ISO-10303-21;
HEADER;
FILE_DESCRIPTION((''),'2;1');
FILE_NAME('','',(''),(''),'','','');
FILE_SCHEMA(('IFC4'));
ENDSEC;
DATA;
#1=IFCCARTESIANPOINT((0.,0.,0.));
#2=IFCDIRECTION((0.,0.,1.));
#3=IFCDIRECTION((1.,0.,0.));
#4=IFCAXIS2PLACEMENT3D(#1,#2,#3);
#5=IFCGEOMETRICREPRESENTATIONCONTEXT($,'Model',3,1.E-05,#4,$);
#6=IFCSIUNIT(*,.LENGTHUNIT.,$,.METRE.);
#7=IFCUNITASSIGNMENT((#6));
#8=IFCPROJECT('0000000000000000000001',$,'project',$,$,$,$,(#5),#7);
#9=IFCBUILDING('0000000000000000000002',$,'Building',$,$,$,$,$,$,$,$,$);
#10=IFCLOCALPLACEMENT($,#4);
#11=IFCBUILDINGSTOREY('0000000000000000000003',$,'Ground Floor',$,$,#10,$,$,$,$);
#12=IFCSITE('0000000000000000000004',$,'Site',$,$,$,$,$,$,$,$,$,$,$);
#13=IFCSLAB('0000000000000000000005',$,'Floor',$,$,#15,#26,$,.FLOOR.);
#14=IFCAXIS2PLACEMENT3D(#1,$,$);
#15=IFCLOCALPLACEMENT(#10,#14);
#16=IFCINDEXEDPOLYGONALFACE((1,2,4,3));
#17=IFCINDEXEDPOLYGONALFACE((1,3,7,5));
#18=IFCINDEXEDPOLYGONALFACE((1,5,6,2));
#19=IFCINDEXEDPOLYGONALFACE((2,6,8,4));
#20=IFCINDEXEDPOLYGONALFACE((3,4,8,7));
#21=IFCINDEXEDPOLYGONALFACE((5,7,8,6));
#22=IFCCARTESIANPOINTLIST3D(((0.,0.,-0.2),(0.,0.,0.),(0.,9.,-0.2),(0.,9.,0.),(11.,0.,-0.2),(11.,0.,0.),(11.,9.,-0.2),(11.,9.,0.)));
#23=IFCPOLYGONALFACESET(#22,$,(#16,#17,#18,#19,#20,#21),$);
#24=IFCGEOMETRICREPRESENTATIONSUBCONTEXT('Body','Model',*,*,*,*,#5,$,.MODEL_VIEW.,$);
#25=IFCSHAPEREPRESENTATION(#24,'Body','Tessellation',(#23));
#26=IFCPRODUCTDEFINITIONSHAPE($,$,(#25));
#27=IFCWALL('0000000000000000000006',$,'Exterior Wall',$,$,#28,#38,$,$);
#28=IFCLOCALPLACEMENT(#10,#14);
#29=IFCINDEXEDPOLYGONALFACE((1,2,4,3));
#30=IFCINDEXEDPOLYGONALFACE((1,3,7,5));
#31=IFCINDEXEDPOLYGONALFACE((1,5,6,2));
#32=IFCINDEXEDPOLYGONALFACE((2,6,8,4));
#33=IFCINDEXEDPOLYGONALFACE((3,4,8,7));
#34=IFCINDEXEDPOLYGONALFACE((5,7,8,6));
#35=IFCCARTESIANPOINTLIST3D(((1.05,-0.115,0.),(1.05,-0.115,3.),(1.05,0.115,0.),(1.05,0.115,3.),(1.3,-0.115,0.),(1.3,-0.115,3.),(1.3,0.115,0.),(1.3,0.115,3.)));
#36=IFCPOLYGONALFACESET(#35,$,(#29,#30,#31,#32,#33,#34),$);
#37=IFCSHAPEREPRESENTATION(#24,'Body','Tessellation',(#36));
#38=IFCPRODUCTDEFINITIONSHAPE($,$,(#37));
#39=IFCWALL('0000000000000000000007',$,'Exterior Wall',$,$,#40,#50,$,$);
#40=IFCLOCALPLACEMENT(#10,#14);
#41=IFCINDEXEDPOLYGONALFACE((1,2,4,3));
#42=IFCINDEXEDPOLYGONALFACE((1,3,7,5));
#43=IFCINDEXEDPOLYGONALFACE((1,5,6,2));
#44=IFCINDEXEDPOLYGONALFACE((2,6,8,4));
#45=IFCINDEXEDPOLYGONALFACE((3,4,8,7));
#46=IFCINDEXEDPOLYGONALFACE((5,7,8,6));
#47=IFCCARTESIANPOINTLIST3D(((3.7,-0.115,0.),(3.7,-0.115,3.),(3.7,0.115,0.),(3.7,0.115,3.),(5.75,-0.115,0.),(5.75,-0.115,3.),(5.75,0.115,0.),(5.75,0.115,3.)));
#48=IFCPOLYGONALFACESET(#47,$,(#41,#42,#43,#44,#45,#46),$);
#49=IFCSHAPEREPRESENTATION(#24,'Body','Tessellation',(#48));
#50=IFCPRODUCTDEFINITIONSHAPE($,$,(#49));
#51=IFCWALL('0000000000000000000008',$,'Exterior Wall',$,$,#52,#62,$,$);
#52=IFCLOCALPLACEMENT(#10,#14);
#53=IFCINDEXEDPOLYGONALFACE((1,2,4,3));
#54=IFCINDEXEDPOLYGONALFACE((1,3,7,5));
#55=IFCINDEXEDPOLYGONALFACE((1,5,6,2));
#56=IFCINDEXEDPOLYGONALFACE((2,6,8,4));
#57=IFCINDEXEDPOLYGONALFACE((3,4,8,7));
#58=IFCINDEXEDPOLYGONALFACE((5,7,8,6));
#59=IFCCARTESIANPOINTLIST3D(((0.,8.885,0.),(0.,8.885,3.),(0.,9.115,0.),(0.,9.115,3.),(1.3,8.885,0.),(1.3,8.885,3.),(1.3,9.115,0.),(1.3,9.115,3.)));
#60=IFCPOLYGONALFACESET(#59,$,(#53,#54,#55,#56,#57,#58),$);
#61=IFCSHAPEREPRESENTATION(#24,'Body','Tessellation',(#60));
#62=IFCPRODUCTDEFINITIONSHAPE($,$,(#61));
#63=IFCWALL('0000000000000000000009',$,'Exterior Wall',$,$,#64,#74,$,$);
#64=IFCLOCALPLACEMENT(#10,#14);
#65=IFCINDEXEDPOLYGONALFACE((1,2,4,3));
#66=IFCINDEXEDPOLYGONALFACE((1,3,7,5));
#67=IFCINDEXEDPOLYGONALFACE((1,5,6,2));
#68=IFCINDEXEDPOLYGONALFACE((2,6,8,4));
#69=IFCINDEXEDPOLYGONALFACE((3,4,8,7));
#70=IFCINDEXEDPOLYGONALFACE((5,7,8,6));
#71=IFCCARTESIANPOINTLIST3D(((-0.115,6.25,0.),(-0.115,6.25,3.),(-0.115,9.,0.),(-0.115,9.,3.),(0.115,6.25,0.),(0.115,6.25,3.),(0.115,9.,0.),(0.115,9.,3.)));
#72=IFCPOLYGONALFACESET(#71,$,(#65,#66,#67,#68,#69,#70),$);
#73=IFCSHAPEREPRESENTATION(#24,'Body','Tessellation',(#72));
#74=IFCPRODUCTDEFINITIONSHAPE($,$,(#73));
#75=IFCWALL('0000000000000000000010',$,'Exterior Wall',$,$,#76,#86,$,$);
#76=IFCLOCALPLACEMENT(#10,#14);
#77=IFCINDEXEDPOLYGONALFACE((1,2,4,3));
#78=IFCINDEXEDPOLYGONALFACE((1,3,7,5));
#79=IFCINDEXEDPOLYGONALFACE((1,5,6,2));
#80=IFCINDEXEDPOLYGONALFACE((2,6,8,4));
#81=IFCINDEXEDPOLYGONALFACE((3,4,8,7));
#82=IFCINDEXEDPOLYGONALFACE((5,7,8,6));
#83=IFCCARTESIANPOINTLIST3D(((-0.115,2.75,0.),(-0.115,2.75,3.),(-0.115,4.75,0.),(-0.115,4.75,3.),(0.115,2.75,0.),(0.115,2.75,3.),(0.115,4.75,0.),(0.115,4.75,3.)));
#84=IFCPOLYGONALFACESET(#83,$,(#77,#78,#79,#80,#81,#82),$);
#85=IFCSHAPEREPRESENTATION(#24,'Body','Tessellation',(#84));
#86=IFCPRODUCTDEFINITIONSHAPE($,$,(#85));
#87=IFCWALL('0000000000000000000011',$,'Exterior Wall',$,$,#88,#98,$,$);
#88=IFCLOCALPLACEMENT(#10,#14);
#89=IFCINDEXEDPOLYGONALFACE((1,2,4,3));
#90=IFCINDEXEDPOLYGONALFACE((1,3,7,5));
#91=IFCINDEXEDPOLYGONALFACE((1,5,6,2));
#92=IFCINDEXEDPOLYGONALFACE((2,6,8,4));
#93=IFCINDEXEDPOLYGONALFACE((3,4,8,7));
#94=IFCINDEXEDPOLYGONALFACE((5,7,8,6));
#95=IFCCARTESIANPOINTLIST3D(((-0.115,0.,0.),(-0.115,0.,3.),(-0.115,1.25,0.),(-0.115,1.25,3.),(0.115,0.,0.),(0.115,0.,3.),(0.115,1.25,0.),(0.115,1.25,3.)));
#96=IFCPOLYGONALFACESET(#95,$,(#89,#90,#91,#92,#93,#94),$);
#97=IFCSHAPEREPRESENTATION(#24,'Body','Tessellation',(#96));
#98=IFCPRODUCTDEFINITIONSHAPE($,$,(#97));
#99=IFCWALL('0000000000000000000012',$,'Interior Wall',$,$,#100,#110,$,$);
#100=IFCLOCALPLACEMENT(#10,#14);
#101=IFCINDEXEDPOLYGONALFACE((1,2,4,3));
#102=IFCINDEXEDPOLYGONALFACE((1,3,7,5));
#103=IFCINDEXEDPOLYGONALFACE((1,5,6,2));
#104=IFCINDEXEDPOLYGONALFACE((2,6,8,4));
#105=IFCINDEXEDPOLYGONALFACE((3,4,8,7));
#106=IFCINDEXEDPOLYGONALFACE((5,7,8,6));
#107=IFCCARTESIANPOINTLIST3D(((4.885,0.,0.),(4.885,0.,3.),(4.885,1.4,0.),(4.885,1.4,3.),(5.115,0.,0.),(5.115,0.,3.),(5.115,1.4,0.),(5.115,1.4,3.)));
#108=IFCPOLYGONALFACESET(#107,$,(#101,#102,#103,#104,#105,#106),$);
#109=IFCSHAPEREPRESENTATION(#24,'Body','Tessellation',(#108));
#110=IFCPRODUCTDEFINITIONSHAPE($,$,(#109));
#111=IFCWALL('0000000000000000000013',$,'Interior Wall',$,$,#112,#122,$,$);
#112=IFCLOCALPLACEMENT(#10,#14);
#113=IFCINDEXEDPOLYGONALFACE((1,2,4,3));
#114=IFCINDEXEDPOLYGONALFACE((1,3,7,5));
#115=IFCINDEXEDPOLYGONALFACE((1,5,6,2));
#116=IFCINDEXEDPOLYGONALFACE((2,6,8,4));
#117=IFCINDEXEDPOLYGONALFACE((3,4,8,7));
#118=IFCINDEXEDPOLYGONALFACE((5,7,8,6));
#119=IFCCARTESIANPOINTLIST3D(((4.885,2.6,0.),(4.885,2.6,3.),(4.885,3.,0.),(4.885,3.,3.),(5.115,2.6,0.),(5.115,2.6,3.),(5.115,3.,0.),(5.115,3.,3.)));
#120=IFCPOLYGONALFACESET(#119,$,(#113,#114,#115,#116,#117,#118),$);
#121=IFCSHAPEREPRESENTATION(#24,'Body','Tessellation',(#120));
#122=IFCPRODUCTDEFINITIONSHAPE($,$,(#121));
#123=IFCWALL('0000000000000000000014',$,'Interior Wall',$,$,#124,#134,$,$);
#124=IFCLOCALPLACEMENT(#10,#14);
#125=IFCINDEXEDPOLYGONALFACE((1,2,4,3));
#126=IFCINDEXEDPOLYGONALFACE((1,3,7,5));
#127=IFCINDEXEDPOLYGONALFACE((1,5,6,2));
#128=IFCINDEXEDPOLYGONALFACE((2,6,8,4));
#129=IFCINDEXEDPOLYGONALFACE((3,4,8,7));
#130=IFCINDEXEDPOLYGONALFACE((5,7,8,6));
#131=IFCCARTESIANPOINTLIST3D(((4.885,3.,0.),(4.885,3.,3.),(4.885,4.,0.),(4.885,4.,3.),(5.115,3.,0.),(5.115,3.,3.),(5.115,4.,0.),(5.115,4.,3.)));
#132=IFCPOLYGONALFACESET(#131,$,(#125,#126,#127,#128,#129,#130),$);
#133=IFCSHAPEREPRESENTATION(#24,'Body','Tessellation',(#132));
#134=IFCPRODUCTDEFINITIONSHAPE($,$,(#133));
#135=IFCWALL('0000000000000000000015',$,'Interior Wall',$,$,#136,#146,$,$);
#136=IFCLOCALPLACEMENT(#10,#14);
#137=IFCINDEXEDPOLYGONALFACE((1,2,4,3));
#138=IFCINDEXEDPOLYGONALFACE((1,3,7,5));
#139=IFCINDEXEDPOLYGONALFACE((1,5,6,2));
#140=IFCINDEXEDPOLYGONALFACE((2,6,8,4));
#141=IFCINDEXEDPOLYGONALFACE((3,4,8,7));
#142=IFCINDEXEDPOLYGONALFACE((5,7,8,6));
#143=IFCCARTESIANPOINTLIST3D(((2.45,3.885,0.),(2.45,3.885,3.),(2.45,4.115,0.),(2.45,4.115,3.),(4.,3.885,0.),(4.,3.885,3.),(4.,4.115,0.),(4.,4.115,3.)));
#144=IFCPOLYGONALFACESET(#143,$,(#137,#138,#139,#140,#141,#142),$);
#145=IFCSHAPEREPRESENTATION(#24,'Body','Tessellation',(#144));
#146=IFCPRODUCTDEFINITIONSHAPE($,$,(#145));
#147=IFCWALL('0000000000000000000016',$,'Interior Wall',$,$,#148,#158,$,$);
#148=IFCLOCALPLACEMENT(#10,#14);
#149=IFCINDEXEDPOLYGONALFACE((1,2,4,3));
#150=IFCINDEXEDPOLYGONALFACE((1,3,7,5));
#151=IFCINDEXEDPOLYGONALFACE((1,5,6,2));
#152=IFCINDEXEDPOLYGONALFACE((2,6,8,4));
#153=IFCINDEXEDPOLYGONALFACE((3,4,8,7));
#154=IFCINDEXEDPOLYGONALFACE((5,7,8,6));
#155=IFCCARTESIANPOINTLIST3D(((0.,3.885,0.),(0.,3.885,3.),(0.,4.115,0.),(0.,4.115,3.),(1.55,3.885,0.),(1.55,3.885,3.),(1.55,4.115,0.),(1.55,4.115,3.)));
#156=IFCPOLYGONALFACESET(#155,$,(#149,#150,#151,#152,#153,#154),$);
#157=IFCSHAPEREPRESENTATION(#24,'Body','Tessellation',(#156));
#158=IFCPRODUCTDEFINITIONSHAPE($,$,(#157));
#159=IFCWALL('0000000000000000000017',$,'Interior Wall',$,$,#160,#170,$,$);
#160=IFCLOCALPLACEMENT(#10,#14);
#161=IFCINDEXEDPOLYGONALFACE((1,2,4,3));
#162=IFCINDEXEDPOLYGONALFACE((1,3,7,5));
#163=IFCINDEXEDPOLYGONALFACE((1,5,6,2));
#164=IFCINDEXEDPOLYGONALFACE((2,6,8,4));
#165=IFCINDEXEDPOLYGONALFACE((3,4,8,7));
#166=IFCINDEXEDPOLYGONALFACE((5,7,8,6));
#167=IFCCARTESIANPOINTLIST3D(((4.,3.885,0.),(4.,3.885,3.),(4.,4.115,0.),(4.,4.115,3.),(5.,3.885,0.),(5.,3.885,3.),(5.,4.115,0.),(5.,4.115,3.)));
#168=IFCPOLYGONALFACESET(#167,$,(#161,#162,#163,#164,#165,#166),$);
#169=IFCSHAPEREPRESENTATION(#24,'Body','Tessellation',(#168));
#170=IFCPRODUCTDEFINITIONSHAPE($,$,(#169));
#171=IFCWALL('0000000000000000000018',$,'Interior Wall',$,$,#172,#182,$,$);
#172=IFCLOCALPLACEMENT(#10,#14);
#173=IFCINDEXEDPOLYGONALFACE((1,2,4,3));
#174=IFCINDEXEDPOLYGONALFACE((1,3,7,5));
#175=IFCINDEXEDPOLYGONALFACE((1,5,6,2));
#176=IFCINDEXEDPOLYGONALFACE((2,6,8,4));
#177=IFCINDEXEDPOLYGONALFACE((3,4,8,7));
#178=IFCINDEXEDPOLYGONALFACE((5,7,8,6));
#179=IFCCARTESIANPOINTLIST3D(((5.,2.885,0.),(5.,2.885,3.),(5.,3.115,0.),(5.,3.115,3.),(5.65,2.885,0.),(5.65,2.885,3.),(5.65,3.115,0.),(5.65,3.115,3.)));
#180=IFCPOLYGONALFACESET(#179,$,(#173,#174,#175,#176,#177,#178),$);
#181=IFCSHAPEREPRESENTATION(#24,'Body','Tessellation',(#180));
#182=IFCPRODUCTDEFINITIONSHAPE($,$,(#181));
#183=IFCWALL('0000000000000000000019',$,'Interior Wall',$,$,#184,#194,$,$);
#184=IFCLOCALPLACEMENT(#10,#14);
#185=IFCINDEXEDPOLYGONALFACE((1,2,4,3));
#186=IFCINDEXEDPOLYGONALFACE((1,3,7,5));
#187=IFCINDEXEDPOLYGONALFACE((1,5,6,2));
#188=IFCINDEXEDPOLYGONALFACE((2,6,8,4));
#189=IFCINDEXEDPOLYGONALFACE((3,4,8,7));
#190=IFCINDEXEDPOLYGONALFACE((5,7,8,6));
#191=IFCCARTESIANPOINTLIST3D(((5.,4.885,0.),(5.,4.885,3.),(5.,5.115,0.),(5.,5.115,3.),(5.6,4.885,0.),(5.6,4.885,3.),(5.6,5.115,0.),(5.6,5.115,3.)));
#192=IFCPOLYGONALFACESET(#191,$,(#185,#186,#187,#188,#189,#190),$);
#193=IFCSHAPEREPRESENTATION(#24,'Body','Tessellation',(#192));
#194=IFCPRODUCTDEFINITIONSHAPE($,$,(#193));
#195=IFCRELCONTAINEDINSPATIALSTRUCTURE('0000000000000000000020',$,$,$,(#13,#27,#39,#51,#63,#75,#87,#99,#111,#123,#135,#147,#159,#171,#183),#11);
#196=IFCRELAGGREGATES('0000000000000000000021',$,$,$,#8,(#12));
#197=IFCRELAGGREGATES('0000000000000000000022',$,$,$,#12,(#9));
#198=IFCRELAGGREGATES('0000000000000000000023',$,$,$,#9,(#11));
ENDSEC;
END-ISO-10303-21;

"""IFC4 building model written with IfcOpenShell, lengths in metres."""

from ifc_helpers import new_model, si_unit, frame, origin_with_axes, place, context, subcontext, project, spatial, indexed_curve, outline, extrude, element, save


model = new_model("IFC4")

# Units and contexts
model_context = context("Model", 3, precision=1e-05, world=origin_with_axes())
body_context = subcontext(model_context, "Body", "Model", "MODEL_VIEW")
ifc_project = project(units=[si_unit("LENGTHUNIT", "METRE")], contexts=[model_context])

# Site, building, storey
site = spatial("IfcSite", under=ifc_project, Name="Site")
building = spatial("IfcBuilding", under=site, Name="Building")
storey_placement = place(None, origin_with_axes())
storey = spatial("IfcBuildingStorey", under=building, at=storey_placement, Name="Ground Floor")

# Slab
slab_placement = place(storey_placement, frame((0.0, 0.0, -0.2), z_axis=(0.0, 0.0, 1.0), x_axis=(1.0, 0.0, 0.0)))
element("IfcSlab", 1, at=slab_placement, inside=storey, Name="Floor", PredefinedType="FLOOR", context=body_context, shape_type="SweptSolid", body=[
    extrude(outline(indexed_curve([(0.0, 0.0), (11.0, 0.0), (11.0, 9.0), (0.0, 9.0)])), None, (0.0, 0.0, 1.0), 0.2),
])

# Walls
wall_1_placement = place(storey_placement, frame((1.05, 0.0, 0.0), z_axis=(0.0, 0.0, 1.0), x_axis=(1.0, 0.0, 0.0)))
element("IfcWall", 2, at=wall_1_placement, inside=storey, Name="Exterior Wall", context=body_context, shape_type="SweptSolid", body=[
    extrude(outline(indexed_curve([(0.0, 0.0), (0.0, 0.23), (0.25, 0.23), (0.25, 0.0), (0.0, 0.0)], self_intersect=False)), frame((0.0, -0.115, 0.0), z_axis=(0.0, 0.0, 1.0), x_axis=(1.0, 0.0, 0.0)), (0.0, 0.0, 1.0), 3.0),
])
wall_2_placement = place(storey_placement, frame((3.7, 0.0, 0.0), z_axis=(0.0, 0.0, 1.0), x_axis=(1.0, 0.0, 0.0)))
element("IfcWall", 3, at=wall_2_placement, inside=storey, Name="Exterior Wall", context=body_context, shape_type="SweptSolid", body=[
    extrude(outline(indexed_curve([(0.0, 0.0), (0.0, 0.23), (2.05, 0.23), (2.05, 0.0), (0.0, 0.0)], self_intersect=False)), frame((0.0, -0.115, 0.0), z_axis=(0.0, 0.0, 1.0), x_axis=(1.0, 0.0, 0.0)), (0.0, 0.0, 1.0), 3.0),
])
wall_3_placement = place(storey_placement, frame((1.3, 9.0, 0.0), z_axis=(0.0, 0.0, 1.0), x_axis=(-1.0, 0.0, 0.0)))
element("IfcWall", 4, at=wall_3_placement, inside=storey, Name="Exterior Wall", context=body_context, shape_type="SweptSolid", body=[
    extrude(outline(indexed_curve([(0.0, 0.0), (0.0, 0.23), (1.3, 0.23), (1.3, 0.0), (0.0, 0.0)], self_intersect=False)), frame((0.0, -0.115, 0.0), z_axis=(0.0, 0.0, 1.0), x_axis=(1.0, 0.0, 0.0)), (0.0, 0.0, 1.0), 3.0),
])
wall_4_placement = place(storey_placement, frame((0.0, 9.0, 0.0), z_axis=(0.0, 0.0, 1.0), x_axis=(0.0, -1.0, 0.0)))
element("IfcWall", 5, at=wall_4_placement, inside=storey, Name="Exterior Wall", context=body_context, shape_type="SweptSolid", body=[
    extrude(outline(indexed_curve([(0.0, 0.0), (0.0, 0.23), (2.75, 0.23), (2.75, 0.0), (0.0, 0.0)], self_intersect=False)), frame((0.0, -0.115, 0.0), z_axis=(0.0, 0.0, 1.0), x_axis=(1.0, 0.0, 0.0)), (0.0, 0.0, 1.0), 3.0),
])
wall_5_placement = place(storey_placement, frame((0.0, 4.75, 0.0), z_axis=(0.0, 0.0, 1.0), x_axis=(0.0, -1.0, 0.0)))
element("IfcWall", 6, at=wall_5_placement, inside=storey, Name="Exterior Wall", context=body_context, shape_type="SweptSolid", body=[
    extrude(outline(indexed_curve([(0.0, 0.0), (0.0, 0.23), (2.0, 0.23), (2.0, 0.0), (0.0, 0.0)], self_intersect=False)), frame((0.0, -0.115, 0.0), z_axis=(0.0, 0.0, 1.0), x_axis=(1.0, 0.0, 0.0)), (0.0, 0.0, 1.0), 3.0),
])
wall_6_placement = place(storey_placement, frame((0.0, 1.25, 0.0), z_axis=(0.0, 0.0, 1.0), x_axis=(0.0, -1.0, 0.0)))
element("IfcWall", 7, at=wall_6_placement, inside=storey, Name="Exterior Wall", context=body_context, shape_type="SweptSolid", body=[
    extrude(outline(indexed_curve([(0.0, 0.0), (0.0, 0.23), (1.25, 0.23), (1.25, 0.0), (0.0, 0.0)], self_intersect=False)), frame((0.0, -0.115, 0.0), z_axis=(0.0, 0.0, 1.0), x_axis=(1.0, 0.0, 0.0)), (0.0, 0.0, 1.0), 3.0),
])
wall_7_placement = place(storey_placement, frame((5.0, 0.0, 0.0), z_axis=(0.0, 0.0, 1.0), x_axis=(0.0, 1.0, 0.0)))
element("IfcWall", 8, at=wall_7_placement, inside=storey, Name="Interior Wall", context=body_context, shape_type="SweptSolid", body=[
    extrude(outline(indexed_curve([(0.0, 0.0), (0.0, 0.23), (1.4, 0.23), (1.4, 0.0), (0.0, 0.0)], self_intersect=False)), frame((0.0, -0.115, 0.0), z_axis=(0.0, 0.0, 1.0), x_axis=(1.0, 0.0, 0.0)), (0.0, 0.0, 1.0), 3.0),
])
wall_8_placement = place(storey_placement, frame((5.0, 2.6, 0.0), z_axis=(0.0, 0.0, 1.0), x_axis=(0.0, 1.0, 0.0)))
element("IfcWall", 9, at=wall_8_placement, inside=storey, Name="Interior Wall", context=body_context, shape_type="SweptSolid", body=[
    extrude(outline(indexed_curve([(0.0, 0.0), (0.0, 0.23), (0.4, 0.23), (0.4, 0.0), (0.0, 0.0)], self_intersect=False)), frame((0.0, -0.115, 0.0), z_axis=(0.0, 0.0, 1.0), x_axis=(1.0, 0.0, 0.0)), (0.0, 0.0, 1.0), 3.0),
])
wall_9_placement = place(storey_placement, frame((5.0, 3.0, 0.0), z_axis=(0.0, 0.0, 1.0), x_axis=(0.0, 1.0, 0.0)))
element("IfcWall", 10, at=wall_9_placement, inside=storey, Name="Interior Wall", context=body_context, shape_type="SweptSolid", body=[
    extrude(outline(indexed_curve([(0.0, 0.0), (0.0, 0.23), (1.0, 0.23), (1.0, 0.0), (0.0, 0.0)], self_intersect=False)), frame((0.0, -0.115, 0.0), z_axis=(0.0, 0.0, 1.0), x_axis=(1.0, 0.0, 0.0)), (0.0, 0.0, 1.0), 3.0),
])
for number, where, z_axis, x_axis, name in (
    (11, (4.0, 4.0, 0.0), (0.0, 0.0, 1.0), (-1.0, 0.0, 0.0), "Interior Wall"),
    (12, (1.55, 4.0, 0.0), (0.0, 0.0, 1.0), (-1.0, 0.0, 0.0), "Interior Wall"),
):
    element("IfcWall", number, at=place(storey_placement, frame(where, z_axis=z_axis, x_axis=x_axis)), inside=storey, Name=name, context=body_context, shape_type="SweptSolid", body=[
        extrude(outline(indexed_curve([(0.0, 0.0), (0.0, 0.23), (1.55, 0.23), (1.55, 0.0), (0.0, 0.0)], self_intersect=False)), frame((0.0, -0.115, 0.0), z_axis=(0.0, 0.0, 1.0), x_axis=(1.0, 0.0, 0.0)), (0.0, 0.0, 1.0), 3.0),
    ])
wall_10_placement = place(storey_placement, frame((5.0, 4.0, 0.0), z_axis=(0.0, 0.0, 1.0), x_axis=(-1.0, 0.0, 0.0)))
element("IfcWall", 13, at=wall_10_placement, inside=storey, Name="Interior Wall", context=body_context, shape_type="SweptSolid", body=[
    extrude(outline(indexed_curve([(0.0, 0.0), (0.0, 0.23), (1.0, 0.23), (1.0, 0.0), (0.0, 0.0)], self_intersect=False)), frame((0.0, -0.115, 0.0), z_axis=(0.0, 0.0, 1.0), x_axis=(1.0, 0.0, 0.0)), (0.0, 0.0, 1.0), 3.0),
])
wall_11_placement = place(storey_placement, frame((5.65, 3.0, 0.0), z_axis=(0.0, 0.0, 1.0), x_axis=(-1.0, 0.0, 0.0)))
element("IfcWall", 14, at=wall_11_placement, inside=storey, Name="Interior Wall", context=body_context, shape_type="SweptSolid", body=[
    extrude(outline(indexed_curve([(0.0, 0.0), (0.0, 0.23), (0.65, 0.23), (0.65, 0.0), (0.0, 0.0)], self_intersect=False)), frame((0.0, -0.115, 0.0), z_axis=(0.0, 0.0, 1.0), x_axis=(1.0, 0.0, 0.0)), (0.0, 0.0, 1.0), 3.0),
])
wall_12_placement = place(storey_placement, frame((5.6, 5.0, 0.0), z_axis=(0.0, 0.0, 1.0), x_axis=(-1.0, 0.0, 0.0)))
element("IfcWall", 15, at=wall_12_placement, inside=storey, Name="Interior Wall", context=body_context, shape_type="SweptSolid", body=[
    extrude(outline(indexed_curve([(0.0, 0.0), (0.0, 0.23), (0.6, 0.23), (0.6, 0.0), (0.0, 0.0)], self_intersect=False)), frame((0.0, -0.115, 0.0), z_axis=(0.0, 0.0, 1.0), x_axis=(1.0, 0.0, 0.0)), (0.0, 0.0, 1.0), 3.0),
])

save(model, "model.ifc")
